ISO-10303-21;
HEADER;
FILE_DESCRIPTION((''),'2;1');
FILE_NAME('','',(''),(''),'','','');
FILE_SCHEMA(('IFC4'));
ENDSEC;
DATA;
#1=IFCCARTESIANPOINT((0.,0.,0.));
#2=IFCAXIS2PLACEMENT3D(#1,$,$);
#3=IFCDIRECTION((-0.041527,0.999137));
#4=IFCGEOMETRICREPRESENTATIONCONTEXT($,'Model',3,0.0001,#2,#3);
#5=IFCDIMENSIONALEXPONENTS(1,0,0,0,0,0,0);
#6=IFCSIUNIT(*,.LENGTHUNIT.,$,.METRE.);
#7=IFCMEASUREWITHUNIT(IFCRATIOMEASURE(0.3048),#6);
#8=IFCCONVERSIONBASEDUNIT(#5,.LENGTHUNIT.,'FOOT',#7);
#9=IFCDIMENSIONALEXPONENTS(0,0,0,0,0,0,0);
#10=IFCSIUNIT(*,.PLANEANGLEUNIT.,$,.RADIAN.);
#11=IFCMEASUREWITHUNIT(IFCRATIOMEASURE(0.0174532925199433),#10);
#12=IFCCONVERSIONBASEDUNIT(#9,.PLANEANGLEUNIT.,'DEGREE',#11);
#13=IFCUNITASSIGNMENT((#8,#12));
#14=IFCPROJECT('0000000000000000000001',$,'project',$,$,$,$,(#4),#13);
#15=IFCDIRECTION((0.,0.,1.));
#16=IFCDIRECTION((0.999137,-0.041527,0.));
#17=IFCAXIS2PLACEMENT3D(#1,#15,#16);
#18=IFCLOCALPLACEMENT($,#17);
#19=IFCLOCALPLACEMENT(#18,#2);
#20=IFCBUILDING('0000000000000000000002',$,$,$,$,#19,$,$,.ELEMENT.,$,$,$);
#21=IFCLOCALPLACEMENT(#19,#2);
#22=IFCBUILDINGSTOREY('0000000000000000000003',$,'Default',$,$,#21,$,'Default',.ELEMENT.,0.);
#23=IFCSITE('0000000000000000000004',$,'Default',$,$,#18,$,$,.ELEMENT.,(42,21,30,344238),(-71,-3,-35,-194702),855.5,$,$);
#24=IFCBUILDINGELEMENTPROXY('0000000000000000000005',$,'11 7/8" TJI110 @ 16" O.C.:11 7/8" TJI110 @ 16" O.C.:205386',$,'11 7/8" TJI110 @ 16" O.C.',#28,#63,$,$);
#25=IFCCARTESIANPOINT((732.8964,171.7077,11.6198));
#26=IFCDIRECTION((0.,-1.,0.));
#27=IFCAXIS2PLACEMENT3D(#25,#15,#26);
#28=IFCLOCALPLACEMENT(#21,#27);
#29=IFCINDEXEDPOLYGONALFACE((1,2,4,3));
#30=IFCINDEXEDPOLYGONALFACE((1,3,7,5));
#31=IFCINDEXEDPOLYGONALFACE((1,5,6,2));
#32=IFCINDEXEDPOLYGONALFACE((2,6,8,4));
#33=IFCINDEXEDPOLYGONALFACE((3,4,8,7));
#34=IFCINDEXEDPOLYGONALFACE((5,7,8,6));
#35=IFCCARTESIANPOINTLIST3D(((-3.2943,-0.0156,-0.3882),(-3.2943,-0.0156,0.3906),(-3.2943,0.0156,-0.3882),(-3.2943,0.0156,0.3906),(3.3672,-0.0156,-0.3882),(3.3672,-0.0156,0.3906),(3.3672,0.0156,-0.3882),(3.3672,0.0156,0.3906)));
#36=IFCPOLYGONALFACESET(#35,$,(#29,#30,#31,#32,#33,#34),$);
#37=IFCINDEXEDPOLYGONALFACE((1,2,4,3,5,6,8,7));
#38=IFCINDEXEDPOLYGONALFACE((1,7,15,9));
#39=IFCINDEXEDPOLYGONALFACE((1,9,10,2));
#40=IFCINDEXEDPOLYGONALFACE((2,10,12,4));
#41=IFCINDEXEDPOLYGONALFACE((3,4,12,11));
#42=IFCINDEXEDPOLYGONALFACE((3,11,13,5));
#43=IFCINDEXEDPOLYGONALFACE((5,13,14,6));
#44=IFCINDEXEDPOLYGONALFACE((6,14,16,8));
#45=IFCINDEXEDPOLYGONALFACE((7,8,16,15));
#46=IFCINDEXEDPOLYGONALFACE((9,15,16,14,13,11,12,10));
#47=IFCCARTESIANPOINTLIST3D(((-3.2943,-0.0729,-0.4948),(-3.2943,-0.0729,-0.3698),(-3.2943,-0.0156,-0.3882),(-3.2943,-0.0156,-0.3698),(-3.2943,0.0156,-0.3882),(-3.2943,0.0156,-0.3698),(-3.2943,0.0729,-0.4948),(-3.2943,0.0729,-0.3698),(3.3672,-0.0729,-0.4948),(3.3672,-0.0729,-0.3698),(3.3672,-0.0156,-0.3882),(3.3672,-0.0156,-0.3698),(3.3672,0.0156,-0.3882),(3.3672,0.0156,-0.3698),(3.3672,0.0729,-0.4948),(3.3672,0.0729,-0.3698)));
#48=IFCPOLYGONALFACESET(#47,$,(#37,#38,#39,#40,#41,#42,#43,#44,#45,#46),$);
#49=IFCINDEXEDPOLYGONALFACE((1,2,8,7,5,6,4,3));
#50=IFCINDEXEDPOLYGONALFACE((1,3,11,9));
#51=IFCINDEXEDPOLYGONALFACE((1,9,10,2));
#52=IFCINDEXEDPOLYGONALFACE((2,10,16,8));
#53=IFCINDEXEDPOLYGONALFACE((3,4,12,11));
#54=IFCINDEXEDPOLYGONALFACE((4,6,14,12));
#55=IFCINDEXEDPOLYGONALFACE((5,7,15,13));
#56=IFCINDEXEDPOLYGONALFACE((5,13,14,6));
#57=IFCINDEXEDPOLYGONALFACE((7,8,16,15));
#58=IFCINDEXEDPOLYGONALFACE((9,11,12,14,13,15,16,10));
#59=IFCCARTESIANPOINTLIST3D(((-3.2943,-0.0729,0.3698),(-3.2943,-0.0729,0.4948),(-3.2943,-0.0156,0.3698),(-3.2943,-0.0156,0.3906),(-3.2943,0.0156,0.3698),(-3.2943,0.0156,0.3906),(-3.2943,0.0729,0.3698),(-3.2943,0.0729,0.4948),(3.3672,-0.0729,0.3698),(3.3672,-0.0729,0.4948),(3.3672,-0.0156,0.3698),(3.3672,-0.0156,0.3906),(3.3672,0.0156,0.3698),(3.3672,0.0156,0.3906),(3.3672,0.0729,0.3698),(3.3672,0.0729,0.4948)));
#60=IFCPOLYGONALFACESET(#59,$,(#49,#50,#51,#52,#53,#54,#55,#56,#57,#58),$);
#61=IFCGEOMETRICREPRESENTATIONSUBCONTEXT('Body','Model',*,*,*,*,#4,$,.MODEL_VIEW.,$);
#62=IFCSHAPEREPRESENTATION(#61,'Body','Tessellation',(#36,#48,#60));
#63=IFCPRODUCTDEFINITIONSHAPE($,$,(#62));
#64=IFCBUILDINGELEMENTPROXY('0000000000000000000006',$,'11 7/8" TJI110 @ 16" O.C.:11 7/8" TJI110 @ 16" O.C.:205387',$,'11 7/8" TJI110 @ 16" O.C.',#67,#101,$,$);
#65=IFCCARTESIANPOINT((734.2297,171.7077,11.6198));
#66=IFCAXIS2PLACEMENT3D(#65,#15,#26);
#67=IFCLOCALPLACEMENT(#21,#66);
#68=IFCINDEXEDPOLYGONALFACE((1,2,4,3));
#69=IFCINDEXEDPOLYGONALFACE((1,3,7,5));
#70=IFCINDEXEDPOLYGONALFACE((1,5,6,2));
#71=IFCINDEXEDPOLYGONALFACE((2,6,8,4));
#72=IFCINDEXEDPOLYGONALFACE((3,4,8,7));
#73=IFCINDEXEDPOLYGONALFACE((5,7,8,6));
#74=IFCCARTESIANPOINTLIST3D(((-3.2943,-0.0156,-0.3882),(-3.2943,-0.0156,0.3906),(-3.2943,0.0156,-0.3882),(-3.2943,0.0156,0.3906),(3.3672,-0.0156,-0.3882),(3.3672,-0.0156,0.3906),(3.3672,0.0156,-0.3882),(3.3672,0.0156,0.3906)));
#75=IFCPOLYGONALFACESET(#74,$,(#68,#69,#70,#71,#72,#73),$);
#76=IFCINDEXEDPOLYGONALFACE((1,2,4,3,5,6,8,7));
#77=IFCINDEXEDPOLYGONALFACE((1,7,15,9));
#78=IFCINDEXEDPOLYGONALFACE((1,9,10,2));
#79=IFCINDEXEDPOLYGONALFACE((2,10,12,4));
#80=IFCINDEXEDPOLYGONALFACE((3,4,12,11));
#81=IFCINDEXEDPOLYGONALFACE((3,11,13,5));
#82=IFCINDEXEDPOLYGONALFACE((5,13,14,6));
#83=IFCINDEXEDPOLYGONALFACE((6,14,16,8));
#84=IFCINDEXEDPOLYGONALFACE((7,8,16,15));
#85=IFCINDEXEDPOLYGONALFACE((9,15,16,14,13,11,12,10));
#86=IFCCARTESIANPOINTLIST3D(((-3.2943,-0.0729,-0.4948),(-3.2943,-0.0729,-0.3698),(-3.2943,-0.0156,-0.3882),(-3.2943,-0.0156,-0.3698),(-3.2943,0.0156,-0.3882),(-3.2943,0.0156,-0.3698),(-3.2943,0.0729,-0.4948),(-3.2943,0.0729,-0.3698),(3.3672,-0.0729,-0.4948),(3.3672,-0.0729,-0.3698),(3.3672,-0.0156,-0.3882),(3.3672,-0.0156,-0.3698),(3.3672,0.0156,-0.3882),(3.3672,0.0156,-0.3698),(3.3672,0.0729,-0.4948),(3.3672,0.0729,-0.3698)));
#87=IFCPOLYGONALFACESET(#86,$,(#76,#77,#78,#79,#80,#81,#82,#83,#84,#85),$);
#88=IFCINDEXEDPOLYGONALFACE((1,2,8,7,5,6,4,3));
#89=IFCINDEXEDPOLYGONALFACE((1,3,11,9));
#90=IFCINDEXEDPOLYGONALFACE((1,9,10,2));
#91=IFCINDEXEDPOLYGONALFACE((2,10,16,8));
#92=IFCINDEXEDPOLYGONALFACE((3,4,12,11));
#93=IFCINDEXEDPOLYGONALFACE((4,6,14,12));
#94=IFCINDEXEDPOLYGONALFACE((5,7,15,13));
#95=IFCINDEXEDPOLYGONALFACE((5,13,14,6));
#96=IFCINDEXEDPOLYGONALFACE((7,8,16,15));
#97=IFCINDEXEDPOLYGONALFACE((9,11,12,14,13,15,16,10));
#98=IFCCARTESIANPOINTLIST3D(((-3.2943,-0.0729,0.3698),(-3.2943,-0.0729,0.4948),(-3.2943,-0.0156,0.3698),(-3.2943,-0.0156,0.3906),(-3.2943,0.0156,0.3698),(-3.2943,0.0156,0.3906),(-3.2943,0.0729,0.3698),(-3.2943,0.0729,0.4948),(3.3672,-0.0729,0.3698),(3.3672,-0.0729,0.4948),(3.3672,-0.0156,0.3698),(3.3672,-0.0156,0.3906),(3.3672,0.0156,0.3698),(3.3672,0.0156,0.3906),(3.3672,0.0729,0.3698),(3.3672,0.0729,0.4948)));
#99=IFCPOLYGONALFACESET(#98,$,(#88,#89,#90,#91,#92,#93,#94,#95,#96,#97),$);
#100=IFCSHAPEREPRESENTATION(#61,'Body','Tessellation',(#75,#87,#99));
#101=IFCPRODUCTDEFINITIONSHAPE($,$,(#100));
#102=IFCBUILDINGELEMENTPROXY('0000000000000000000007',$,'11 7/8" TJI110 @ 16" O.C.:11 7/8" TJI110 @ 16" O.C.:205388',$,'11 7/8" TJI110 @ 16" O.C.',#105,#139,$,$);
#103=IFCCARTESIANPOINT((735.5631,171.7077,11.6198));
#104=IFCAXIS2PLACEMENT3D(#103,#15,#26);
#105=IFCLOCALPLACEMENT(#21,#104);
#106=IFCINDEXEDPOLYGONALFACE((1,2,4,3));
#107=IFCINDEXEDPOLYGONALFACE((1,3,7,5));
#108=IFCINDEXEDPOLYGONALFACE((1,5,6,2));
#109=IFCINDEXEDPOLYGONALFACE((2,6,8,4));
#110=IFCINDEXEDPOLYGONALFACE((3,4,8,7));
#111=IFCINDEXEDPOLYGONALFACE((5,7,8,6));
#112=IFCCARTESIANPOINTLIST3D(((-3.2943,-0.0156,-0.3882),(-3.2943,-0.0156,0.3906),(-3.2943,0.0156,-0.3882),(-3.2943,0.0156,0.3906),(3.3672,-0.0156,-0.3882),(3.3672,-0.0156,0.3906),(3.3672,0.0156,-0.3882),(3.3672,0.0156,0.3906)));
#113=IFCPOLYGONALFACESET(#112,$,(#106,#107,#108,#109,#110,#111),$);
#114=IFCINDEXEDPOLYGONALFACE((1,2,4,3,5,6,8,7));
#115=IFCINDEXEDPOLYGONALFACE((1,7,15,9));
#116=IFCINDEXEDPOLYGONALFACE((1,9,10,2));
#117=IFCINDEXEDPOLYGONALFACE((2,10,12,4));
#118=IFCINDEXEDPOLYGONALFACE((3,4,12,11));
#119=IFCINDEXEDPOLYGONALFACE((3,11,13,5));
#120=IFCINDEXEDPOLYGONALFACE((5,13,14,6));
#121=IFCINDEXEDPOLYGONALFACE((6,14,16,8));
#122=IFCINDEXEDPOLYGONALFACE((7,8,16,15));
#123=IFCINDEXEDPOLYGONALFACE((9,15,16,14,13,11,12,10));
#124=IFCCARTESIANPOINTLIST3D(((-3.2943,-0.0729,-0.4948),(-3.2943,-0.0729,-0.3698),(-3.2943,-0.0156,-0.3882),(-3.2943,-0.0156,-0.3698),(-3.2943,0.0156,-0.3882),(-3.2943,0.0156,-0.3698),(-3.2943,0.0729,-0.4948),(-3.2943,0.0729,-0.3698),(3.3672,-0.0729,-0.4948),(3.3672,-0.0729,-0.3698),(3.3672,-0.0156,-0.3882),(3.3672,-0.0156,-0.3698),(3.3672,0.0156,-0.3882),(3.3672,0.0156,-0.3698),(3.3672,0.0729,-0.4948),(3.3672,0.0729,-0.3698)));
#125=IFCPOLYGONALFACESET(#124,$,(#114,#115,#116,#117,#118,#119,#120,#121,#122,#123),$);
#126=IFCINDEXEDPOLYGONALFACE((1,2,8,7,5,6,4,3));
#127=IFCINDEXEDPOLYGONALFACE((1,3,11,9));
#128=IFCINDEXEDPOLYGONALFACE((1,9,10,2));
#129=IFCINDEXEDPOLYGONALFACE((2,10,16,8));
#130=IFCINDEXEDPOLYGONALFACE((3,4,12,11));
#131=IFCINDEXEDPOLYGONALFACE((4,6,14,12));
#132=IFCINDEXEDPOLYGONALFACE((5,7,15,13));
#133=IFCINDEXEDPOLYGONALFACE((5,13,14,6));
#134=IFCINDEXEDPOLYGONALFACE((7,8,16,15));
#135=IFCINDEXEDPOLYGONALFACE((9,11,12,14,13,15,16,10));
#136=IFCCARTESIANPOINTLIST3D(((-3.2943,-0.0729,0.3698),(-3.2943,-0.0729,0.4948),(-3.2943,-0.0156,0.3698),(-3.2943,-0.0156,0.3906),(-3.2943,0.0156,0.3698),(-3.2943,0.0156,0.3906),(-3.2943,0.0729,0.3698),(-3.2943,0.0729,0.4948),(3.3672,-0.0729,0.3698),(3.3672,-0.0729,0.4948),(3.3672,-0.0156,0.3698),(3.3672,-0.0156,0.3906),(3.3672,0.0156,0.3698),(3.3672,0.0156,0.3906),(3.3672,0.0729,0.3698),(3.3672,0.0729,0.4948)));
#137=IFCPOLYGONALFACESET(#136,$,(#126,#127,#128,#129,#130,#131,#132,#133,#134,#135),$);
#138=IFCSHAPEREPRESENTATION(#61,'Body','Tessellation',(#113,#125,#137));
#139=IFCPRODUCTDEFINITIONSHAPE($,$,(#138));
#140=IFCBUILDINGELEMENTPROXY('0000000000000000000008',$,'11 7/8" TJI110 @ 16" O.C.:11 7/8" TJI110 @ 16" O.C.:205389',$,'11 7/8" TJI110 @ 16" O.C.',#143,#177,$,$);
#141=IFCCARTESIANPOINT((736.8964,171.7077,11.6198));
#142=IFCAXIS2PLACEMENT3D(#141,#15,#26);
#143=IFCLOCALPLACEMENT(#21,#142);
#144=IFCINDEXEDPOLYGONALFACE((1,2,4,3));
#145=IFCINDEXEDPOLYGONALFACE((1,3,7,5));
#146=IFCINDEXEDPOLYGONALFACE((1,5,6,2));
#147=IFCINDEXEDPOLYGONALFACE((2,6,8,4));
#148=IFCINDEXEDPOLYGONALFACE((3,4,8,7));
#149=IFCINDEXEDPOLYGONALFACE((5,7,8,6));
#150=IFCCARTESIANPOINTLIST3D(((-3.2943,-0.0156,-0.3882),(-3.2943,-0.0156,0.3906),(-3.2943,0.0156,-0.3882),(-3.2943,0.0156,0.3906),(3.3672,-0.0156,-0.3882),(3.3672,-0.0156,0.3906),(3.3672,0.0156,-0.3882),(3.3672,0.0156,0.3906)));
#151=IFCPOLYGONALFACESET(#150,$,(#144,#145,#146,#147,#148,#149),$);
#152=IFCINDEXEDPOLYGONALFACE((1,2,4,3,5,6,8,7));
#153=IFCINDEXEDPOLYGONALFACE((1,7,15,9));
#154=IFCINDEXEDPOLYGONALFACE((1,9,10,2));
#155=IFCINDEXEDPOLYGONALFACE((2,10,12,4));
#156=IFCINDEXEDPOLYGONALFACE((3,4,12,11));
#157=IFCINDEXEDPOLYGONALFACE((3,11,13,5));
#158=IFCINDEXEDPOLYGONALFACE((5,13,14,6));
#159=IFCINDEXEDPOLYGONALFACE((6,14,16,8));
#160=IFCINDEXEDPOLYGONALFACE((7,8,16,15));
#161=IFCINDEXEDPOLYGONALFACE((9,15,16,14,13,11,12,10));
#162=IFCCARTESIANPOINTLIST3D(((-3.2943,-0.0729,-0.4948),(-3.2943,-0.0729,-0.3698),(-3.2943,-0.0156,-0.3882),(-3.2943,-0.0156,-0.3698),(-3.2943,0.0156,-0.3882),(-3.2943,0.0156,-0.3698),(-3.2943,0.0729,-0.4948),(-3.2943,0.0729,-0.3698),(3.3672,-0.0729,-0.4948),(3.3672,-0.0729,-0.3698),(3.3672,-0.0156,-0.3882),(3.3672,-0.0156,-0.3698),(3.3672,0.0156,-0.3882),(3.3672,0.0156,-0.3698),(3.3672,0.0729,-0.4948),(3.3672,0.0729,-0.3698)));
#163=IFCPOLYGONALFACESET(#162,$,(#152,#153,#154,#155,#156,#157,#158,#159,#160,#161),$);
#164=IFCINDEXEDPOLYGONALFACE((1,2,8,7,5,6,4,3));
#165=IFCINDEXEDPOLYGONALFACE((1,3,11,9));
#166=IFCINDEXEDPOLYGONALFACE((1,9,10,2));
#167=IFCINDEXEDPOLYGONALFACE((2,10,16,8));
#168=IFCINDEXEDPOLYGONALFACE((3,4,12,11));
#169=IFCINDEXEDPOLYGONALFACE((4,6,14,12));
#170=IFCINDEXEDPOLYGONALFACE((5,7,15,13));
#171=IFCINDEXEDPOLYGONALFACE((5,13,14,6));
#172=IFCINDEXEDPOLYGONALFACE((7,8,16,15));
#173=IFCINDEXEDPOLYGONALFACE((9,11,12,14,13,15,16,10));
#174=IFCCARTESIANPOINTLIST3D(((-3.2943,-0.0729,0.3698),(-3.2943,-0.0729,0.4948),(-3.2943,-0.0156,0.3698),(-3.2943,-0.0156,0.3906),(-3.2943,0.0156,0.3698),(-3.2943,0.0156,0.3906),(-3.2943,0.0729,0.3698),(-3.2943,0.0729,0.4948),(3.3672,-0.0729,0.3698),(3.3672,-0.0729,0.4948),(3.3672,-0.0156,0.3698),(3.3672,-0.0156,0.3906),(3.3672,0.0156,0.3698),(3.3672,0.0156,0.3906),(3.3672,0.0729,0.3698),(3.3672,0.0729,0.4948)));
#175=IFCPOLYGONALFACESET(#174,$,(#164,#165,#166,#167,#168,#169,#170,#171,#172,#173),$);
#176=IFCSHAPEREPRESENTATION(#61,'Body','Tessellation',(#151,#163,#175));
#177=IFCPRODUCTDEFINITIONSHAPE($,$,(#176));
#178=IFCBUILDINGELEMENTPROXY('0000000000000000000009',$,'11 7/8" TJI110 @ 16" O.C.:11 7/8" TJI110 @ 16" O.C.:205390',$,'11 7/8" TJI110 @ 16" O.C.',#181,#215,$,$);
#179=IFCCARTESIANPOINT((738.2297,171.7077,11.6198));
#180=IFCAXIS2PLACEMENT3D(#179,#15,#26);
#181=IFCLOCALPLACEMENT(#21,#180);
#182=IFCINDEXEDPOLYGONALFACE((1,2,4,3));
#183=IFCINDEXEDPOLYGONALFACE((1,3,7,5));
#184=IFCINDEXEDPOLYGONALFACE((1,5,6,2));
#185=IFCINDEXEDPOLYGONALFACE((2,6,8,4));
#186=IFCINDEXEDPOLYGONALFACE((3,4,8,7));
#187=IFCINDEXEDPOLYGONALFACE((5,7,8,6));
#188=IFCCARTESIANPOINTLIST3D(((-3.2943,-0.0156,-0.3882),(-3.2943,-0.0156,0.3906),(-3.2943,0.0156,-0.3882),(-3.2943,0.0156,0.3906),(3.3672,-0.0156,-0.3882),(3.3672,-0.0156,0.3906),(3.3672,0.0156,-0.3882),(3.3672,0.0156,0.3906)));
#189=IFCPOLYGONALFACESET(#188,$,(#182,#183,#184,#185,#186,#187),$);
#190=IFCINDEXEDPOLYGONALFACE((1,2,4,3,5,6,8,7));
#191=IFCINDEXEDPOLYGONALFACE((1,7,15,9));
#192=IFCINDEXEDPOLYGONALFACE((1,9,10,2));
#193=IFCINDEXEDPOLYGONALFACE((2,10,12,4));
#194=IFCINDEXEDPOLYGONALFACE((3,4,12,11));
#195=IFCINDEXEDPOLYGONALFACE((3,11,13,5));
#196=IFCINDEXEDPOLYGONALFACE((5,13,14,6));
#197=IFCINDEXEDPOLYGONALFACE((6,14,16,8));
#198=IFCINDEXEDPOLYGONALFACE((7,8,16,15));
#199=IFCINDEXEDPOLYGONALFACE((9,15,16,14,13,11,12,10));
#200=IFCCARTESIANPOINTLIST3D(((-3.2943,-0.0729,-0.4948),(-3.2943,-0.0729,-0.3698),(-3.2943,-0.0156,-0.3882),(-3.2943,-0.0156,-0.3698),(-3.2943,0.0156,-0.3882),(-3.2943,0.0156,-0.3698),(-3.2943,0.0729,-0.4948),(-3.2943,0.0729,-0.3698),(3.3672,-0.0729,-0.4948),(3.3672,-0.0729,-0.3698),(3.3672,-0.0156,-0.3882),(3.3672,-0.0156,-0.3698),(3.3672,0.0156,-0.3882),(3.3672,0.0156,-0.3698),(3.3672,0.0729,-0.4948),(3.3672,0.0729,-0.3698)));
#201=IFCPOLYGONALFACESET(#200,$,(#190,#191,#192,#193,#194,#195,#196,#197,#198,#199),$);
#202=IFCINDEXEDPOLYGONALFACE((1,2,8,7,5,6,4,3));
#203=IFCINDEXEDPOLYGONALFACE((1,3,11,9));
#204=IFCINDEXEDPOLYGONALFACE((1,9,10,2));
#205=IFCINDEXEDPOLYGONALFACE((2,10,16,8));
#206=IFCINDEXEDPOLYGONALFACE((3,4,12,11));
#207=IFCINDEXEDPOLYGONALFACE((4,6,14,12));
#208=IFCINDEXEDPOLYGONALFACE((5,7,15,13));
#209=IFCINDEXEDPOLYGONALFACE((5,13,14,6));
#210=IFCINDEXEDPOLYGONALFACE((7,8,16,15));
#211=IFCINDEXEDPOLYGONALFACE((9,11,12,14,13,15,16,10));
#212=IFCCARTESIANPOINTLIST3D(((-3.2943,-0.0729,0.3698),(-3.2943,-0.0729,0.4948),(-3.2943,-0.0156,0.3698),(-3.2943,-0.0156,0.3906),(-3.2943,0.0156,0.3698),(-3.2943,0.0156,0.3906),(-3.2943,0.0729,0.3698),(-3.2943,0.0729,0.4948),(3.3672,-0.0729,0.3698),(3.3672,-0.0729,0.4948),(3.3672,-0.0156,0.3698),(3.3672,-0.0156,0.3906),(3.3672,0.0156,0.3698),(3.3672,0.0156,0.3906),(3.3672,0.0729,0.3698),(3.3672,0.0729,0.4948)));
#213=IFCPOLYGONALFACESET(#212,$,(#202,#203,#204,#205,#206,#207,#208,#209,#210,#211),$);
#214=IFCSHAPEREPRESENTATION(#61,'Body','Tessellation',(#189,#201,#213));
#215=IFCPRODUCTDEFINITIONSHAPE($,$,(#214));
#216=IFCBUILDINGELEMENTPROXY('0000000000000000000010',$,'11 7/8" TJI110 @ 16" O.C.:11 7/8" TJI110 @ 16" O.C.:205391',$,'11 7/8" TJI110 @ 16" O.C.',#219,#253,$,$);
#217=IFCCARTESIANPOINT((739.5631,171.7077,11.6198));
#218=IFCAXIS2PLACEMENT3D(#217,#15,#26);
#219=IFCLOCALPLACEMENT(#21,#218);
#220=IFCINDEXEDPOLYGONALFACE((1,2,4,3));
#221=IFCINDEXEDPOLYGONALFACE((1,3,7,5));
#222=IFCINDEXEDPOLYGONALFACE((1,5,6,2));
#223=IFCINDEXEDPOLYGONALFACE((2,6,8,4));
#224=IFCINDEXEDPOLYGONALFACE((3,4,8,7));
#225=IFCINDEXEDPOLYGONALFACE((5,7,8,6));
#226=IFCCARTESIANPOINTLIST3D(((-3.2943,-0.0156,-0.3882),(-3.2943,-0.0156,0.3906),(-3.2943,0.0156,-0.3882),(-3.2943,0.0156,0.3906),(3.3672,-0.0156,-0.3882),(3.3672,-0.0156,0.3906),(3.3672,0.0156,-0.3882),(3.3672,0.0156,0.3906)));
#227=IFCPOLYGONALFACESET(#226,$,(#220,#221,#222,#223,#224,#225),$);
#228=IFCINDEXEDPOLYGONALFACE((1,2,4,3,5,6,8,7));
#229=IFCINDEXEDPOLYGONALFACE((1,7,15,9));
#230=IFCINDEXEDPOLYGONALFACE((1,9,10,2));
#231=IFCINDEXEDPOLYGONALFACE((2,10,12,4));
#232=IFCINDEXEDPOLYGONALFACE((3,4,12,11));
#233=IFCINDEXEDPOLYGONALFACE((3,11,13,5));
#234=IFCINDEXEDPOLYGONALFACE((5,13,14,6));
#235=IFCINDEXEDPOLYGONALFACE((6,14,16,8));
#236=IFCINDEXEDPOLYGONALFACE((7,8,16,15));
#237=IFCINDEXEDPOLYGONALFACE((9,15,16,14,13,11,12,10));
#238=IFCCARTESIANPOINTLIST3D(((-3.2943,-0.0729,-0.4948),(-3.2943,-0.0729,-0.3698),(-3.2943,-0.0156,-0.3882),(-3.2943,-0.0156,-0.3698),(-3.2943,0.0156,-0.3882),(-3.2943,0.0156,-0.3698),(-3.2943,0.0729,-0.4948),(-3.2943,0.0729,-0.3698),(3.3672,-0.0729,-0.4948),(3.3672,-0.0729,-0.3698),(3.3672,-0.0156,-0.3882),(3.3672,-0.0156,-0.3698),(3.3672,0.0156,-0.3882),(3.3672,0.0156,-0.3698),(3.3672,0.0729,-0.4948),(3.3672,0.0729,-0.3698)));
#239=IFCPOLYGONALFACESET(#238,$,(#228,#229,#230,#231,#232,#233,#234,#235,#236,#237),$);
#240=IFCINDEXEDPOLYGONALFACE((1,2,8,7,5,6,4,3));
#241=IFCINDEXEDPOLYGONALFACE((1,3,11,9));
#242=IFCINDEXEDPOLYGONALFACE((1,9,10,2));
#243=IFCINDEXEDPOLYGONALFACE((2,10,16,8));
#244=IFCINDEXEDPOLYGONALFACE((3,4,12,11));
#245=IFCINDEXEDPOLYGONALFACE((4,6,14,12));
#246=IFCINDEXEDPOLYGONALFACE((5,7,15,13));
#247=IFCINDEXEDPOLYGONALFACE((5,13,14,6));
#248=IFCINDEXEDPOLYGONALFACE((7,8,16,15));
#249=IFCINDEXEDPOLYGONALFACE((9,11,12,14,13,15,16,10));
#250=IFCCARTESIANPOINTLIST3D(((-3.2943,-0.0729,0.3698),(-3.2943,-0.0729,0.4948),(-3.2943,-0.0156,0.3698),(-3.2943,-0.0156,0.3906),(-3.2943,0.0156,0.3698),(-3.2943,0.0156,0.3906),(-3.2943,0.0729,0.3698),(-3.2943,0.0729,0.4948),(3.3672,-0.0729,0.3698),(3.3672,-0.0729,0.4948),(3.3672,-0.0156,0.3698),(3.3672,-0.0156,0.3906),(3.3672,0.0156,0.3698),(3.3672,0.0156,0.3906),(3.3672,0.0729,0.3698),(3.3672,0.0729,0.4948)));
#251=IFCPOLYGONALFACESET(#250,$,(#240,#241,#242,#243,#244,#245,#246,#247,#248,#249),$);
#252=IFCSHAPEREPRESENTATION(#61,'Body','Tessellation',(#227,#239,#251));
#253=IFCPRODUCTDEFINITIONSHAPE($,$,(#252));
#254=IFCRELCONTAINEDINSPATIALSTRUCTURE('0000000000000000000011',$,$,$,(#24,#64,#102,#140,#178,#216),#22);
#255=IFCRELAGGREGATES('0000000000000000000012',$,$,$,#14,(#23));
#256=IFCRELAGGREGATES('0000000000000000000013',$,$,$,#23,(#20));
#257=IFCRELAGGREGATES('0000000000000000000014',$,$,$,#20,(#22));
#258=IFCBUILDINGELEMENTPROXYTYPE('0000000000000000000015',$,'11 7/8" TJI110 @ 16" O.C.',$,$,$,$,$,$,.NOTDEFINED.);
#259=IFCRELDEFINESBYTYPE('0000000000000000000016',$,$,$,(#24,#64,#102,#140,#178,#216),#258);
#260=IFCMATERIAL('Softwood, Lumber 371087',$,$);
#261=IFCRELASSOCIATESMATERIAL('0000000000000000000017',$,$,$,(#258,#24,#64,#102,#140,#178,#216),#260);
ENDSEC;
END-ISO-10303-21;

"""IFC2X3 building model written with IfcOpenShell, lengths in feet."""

from ifc_helpers import new_model, entity, si_unit, converted_unit, direction, frame, origin, origin_2d_with_axis, place, context, subcontext, project, spatial, polyline, rectangle, outline, extrude, source, transform, mapped, material, type_object, type_shapes, element, save


model = new_model("IFC2X3")

# Units and contexts
model_context = context("Model", 3, precision=0.0001, world=origin(), true_north=direction((-0.041527, 0.999137)))
body_context = subcontext(model_context, "Body", "Model", "MODEL_VIEW")
ifc_project = project(units=[converted_unit("LENGTHUNIT", "FOOT", entity("IfcRatioMeasure", 0.3048), si_unit("LENGTHUNIT", "METRE"), dimensions=[1, 0, 0, 0, 0, 0, 0]), converted_unit("PLANEANGLEUNIT", "DEGREE", entity("IfcRatioMeasure", 0.0174532925199433), si_unit("PLANEANGLEUNIT", "RADIAN"), dimensions=[0, 0, 0, 0, 0, 0, 0])], contexts=[model_context])

# Site, building, storey
site_placement = place(None, frame((0.0, 0.0, 0.0), z_axis=(0.0, 0.0, 1.0), x_axis=(0.999137, -0.041527, 0.0)))
site = spatial("IfcSite", under=ifc_project, at=site_placement, Name="Default", CompositionType="ELEMENT", RefLatitude=(42, 21, 30, 344238), RefLongitude=(-71, -3, -35, -194702), RefElevation=855.5)
building_placement = place(site_placement, origin())
building = spatial("IfcBuilding", under=site, at=building_placement, CompositionType="ELEMENT")
storey_placement = place(building_placement, origin())
storey = spatial("IfcBuildingStorey", under=building, at=storey_placement, Name="Default", LongName="Default", CompositionType="ELEMENT", Elevation=0.0)

# Building element proxies
ifc_material = material(Name="Softwood, Lumber 371087")
building_element_proxy_type_1 = type_object("IfcBuildingElementProxyType", Name="11 7/8\" TJI110 @ 16\" O.C.", PredefinedType="NOTDEFINED", material=ifc_material)
shared_shape_1 = source(origin(), body_context, "Body", "SweptSolid", [
    extrude(rectangle(XDim=6.6615, YDim=0.0313, at=origin_2d_with_axis()), frame((0.0365, 0.0, -0.3882), z_axis=(0.0, 0.0, 1.0), x_axis=(-1.0, 0.0, 0.0)), (0.0, 0.0, 1.0), 0.7788),
    extrude(outline(polyline([(-0.0891, -0.0729), (0.0359, -0.0729), (0.0359, -0.0156), (0.0174, -0.0156), (0.0174, 0.0156), (0.0359, 0.0156), (0.0359, 0.0729), (-0.0891, 0.0729), (-0.0891, -0.0729)])), frame((-3.2943, 0.0, -0.4056), z_axis=(1.0, 0.0, 0.0), x_axis=(0.0, 0.0, 1.0)), (0.0, 0.0, 1.0), 6.6615),
    extrude(outline(polyline([(-0.0729, -0.0885), (0.0729, -0.0885), (0.0729, 0.0365), (0.0156, 0.0365), (0.0156, 0.0156), (-0.0156, 0.0156), (-0.0156, 0.0365), (-0.0729, 0.0365), (-0.0729, -0.0885)])), frame((-3.2943, 0.0, 0.4062), z_axis=(1.0, 0.0, 0.0), x_axis=(0.0, -1.0, 0.0)), (0.0, 0.0, 1.0), 6.6615),
])
type_shapes(building_element_proxy_type_1, [shared_shape_1])
for number, where, z_axis, x_axis, name in (
    (1, (732.8964, 171.7077, 11.6198), (0.0, 0.0, 1.0), (0.0, -1.0, 0.0), "11 7/8\" TJI110 @ 16\" O.C.:11 7/8\" TJI110 @ 16\" O.C.:205386"),
    (2, (734.2297, 171.7077, 11.6198), (0.0, 0.0, 1.0), (0.0, -1.0, 0.0), "11 7/8\" TJI110 @ 16\" O.C.:11 7/8\" TJI110 @ 16\" O.C.:205387"),
    (3, (735.5631, 171.7077, 11.6198), (0.0, 0.0, 1.0), (0.0, -1.0, 0.0), "11 7/8\" TJI110 @ 16\" O.C.:11 7/8\" TJI110 @ 16\" O.C.:205388"),
    (4, (736.8964, 171.7077, 11.6198), (0.0, 0.0, 1.0), (0.0, -1.0, 0.0), "11 7/8\" TJI110 @ 16\" O.C.:11 7/8\" TJI110 @ 16\" O.C.:205389"),
    (5, (738.2297, 171.7077, 11.6198), (0.0, 0.0, 1.0), (0.0, -1.0, 0.0), "11 7/8\" TJI110 @ 16\" O.C.:11 7/8\" TJI110 @ 16\" O.C.:205390"),
    (6, (739.5631, 171.7077, 11.6198), (0.0, 0.0, 1.0), (0.0, -1.0, 0.0), "11 7/8\" TJI110 @ 16\" O.C.:11 7/8\" TJI110 @ 16\" O.C.:205391"),
):
    element("IfcBuildingElementProxy", number, at=place(storey_placement, frame(where, z_axis=z_axis, x_axis=x_axis)), inside=storey, type_object=building_element_proxy_type_1, material=ifc_material, Name=name, ObjectType="11 7/8\" TJI110 @ 16\" O.C.", context=body_context, shape_type="MappedRepresentation", body=[
        mapped(shared_shape_1, transform((0.0, 0.0, 0.0), scale=1.0)),
    ])

save(model, "model.ifc")
